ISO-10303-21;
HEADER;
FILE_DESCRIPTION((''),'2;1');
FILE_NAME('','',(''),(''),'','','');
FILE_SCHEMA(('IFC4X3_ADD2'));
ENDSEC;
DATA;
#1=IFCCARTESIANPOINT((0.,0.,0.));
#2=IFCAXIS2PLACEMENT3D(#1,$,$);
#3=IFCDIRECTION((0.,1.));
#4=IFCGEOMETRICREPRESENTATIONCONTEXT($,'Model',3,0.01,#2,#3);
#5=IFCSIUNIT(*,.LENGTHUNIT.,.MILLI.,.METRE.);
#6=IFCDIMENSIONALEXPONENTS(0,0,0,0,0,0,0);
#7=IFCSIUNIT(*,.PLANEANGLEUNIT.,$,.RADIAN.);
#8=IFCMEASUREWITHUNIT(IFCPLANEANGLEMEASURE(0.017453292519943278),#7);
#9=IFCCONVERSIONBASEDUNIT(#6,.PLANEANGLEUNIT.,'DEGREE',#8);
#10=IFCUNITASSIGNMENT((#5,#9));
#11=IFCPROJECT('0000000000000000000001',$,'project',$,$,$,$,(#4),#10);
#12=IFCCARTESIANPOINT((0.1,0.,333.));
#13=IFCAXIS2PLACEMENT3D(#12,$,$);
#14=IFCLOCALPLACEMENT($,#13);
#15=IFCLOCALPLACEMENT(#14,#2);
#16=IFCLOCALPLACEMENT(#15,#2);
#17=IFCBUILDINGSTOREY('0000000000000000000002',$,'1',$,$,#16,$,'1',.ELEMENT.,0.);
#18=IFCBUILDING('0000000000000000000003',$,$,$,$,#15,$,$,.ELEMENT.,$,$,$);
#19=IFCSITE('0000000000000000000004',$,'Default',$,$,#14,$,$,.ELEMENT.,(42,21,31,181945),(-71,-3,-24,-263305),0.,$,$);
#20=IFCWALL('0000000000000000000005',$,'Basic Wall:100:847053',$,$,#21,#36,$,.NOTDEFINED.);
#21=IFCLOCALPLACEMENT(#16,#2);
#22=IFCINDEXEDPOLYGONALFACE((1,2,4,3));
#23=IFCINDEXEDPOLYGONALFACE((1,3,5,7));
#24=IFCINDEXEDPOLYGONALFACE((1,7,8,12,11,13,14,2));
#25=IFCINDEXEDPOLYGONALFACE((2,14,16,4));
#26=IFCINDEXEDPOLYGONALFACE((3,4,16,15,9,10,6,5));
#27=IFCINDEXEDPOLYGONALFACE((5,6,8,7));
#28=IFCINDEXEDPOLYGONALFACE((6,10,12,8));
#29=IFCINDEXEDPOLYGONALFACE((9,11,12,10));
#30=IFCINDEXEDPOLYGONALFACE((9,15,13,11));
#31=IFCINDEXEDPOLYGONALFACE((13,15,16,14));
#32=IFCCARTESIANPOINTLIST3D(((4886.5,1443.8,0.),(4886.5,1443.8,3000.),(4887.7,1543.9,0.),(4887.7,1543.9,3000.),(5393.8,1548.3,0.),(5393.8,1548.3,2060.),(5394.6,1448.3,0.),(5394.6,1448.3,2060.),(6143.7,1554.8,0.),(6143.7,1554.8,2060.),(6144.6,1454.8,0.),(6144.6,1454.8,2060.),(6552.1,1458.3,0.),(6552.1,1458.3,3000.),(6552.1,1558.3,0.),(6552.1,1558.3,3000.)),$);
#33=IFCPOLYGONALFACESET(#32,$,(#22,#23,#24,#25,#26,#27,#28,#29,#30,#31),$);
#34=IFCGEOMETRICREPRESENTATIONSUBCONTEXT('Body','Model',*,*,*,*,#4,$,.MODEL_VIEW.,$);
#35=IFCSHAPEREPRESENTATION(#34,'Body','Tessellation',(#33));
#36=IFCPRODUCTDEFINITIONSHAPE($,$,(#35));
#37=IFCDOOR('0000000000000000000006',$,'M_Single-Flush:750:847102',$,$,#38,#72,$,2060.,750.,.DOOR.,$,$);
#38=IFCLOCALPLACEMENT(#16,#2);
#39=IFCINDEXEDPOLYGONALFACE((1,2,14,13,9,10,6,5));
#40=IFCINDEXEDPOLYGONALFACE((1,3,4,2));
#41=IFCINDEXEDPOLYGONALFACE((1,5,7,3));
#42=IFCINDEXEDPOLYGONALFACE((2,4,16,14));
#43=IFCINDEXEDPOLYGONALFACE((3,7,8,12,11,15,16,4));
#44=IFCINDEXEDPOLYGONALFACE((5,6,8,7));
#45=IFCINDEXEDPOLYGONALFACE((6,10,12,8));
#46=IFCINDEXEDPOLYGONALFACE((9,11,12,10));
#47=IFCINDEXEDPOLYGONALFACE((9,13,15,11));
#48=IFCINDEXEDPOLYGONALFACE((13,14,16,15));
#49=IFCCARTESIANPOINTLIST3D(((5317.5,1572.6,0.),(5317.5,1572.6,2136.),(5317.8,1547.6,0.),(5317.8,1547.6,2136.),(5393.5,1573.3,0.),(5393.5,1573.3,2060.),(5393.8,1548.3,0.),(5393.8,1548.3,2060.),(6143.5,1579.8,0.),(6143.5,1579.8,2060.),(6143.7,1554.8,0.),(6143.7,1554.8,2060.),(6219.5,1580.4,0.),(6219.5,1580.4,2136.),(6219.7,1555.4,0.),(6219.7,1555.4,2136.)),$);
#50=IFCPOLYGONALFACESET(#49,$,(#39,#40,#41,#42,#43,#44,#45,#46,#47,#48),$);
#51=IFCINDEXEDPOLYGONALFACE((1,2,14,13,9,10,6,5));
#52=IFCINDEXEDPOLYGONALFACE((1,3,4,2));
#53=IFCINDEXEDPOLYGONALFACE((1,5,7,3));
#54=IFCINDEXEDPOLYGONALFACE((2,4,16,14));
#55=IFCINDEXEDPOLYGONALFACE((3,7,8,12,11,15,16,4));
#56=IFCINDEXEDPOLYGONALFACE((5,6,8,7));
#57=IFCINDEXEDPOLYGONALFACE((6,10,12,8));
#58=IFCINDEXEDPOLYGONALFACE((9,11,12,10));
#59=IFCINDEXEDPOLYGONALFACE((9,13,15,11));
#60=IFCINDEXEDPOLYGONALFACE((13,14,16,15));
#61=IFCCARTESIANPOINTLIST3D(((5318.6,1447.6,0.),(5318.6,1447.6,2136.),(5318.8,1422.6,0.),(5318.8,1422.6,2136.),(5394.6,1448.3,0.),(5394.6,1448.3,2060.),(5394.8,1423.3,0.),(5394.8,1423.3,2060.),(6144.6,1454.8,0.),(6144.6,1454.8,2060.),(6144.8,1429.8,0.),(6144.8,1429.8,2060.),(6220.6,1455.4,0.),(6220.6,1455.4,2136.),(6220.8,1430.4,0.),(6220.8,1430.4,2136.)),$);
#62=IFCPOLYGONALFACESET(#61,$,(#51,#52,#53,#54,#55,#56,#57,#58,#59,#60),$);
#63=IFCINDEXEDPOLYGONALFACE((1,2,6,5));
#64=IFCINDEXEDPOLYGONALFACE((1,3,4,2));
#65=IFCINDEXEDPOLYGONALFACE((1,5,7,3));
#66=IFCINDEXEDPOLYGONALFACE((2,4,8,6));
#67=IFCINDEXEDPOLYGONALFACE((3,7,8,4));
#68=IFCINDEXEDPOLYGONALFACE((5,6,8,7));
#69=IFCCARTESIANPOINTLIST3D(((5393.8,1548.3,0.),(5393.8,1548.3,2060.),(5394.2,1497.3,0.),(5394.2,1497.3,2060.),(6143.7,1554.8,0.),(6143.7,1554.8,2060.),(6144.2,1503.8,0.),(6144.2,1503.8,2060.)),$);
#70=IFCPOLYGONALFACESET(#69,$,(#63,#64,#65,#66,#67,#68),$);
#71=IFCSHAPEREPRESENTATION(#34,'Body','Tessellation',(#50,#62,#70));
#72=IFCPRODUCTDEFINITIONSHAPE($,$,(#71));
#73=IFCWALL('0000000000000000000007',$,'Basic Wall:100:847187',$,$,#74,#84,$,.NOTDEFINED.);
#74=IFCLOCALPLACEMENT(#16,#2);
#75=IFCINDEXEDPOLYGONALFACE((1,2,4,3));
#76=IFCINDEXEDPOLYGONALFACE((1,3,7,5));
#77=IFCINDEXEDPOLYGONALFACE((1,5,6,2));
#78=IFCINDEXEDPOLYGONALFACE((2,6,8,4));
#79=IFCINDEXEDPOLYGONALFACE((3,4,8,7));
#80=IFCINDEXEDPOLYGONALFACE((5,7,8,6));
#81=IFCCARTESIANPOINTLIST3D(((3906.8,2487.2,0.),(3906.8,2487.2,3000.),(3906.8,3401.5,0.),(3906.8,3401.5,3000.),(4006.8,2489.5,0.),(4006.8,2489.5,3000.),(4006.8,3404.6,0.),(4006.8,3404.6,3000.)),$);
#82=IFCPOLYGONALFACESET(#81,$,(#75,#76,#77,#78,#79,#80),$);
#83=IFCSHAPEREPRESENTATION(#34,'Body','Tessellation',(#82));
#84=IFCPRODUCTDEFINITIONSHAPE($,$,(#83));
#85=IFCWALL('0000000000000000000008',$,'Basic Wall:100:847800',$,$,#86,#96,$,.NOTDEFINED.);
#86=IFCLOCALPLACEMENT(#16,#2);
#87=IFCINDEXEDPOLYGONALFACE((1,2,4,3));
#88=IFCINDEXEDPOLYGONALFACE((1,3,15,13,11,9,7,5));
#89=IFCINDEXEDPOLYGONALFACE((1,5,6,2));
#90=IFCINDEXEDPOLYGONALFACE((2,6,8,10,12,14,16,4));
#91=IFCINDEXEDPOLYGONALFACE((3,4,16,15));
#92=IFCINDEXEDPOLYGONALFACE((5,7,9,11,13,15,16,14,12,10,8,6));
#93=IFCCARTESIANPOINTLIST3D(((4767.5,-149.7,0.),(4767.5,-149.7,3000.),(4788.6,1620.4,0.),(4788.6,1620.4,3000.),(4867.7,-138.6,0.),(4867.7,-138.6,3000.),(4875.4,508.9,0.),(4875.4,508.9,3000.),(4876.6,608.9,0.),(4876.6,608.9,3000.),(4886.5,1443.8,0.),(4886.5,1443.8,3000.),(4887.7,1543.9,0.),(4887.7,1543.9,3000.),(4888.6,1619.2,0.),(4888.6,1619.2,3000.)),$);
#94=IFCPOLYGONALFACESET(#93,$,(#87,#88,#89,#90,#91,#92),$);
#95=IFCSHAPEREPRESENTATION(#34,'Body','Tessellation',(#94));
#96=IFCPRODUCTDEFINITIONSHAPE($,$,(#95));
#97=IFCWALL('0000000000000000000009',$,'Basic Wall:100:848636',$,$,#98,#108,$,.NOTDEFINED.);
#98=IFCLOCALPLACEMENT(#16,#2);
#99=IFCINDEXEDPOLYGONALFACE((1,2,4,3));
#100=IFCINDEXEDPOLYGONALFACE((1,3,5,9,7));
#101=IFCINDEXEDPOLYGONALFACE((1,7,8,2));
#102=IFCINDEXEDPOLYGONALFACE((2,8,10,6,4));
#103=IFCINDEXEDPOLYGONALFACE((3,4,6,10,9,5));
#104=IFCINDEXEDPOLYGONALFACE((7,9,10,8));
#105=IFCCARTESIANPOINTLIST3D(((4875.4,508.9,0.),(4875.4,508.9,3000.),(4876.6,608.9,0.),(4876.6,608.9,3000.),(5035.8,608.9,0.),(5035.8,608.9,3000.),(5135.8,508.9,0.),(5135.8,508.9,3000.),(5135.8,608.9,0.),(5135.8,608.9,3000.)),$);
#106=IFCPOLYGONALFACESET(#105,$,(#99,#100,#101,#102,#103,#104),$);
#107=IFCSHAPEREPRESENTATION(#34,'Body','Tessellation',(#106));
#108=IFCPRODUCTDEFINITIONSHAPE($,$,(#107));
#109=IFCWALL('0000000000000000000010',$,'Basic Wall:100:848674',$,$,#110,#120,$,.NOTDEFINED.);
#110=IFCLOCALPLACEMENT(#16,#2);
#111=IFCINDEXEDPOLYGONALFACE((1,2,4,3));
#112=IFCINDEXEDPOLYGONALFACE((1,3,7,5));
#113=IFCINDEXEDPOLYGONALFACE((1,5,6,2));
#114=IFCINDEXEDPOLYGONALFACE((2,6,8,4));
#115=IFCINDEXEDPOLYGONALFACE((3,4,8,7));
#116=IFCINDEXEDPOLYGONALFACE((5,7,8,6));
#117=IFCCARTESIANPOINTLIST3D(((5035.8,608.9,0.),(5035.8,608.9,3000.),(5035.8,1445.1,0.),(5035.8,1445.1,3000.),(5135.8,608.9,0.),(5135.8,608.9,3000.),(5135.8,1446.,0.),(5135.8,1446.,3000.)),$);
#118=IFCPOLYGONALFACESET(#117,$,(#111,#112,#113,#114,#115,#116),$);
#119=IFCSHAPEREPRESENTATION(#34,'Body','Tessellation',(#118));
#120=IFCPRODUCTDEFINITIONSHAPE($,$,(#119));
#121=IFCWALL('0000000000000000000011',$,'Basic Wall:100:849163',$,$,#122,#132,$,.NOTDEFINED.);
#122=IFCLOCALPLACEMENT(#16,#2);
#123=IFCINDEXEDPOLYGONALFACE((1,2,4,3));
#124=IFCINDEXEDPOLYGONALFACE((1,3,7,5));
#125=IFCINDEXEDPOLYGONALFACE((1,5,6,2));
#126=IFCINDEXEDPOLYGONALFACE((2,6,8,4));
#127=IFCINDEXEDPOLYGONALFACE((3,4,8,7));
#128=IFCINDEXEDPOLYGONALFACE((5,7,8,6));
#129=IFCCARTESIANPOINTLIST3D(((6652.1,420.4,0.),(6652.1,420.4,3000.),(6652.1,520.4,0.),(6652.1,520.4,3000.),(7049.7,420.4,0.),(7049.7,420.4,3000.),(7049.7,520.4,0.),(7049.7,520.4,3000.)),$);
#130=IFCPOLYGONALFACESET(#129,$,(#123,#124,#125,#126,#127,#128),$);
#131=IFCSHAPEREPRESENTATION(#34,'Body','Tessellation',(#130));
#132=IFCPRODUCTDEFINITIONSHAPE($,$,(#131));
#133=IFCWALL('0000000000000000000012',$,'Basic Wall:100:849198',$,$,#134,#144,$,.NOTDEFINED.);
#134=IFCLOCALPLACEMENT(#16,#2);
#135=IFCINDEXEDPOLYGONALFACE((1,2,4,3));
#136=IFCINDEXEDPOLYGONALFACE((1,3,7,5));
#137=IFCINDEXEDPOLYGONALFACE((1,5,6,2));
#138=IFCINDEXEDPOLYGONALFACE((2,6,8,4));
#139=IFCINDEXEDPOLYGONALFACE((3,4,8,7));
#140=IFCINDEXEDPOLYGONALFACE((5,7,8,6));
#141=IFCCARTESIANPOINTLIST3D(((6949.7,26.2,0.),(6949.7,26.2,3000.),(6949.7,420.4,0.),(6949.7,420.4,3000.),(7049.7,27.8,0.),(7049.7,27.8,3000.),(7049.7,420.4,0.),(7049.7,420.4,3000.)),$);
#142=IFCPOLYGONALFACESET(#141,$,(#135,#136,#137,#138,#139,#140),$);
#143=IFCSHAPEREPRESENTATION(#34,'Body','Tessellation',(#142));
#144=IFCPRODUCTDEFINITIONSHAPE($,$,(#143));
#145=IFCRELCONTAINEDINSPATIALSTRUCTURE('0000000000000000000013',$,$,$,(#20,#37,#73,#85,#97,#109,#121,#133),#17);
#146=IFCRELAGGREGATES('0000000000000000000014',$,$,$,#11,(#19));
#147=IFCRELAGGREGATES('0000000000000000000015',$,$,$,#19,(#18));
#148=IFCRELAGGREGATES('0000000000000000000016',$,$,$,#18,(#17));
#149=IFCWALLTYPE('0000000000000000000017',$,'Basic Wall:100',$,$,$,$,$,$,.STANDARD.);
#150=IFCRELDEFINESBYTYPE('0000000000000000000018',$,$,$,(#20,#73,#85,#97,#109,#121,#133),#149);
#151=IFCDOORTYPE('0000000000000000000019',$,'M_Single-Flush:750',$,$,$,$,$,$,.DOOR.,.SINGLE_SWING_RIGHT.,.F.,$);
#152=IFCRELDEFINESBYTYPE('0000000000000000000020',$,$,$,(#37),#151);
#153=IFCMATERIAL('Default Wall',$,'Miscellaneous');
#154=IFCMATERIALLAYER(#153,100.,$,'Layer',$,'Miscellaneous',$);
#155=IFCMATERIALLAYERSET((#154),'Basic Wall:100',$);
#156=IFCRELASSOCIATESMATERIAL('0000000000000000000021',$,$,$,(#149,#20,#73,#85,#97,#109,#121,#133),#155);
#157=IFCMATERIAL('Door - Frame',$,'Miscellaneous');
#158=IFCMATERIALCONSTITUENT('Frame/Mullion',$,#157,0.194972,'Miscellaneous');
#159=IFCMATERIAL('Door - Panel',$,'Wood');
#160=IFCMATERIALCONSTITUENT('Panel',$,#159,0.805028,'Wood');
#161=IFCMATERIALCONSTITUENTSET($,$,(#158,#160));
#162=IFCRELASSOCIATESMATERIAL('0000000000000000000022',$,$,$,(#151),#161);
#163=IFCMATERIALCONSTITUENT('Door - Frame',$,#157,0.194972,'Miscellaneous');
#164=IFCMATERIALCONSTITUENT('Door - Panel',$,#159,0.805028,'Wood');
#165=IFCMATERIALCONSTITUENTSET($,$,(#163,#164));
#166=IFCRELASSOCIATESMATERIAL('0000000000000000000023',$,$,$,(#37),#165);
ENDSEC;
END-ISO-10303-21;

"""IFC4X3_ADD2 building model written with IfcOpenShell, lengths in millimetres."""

from ifc_helpers import new_model, entity, si_unit, converted_unit, direction, frame, frame_2d, origin, origin_2d_with_axis, place, context, subcontext, project, spatial, polyline, rectangle, outline, extrude, source, transform, mapped, material, layer, layer_set, constituent, constituent_set, type_object, type_shapes, element, fill, save


model = new_model("IFC4X3_ADD2")

# Units and contexts
model_context = context("Model", 3, precision=0.01, world=origin(), true_north=direction((0.0, 1.0)))
body_context = subcontext(model_context, "Body", "Model", "MODEL_VIEW")
ifc_project = project(units=[si_unit("LENGTHUNIT", "METRE", prefix="MILLI"), converted_unit("PLANEANGLEUNIT", "DEGREE", entity("IfcPlaneAngleMeasure", 0.017453292519943278), si_unit("PLANEANGLEUNIT", "RADIAN"), dimensions=[0, 0, 0, 0, 0, 0, 0])], contexts=[model_context])

# Site, building, storey
site_placement = place(None, frame((0.1, 0.0, 333.0)))
site = spatial("IfcSite", under=ifc_project, at=site_placement, Name="Default", CompositionType="ELEMENT", RefLatitude=(42, 21, 31, 181945), RefLongitude=(-71, -3, -24, -263305), RefElevation=0.0)
building_placement = place(site_placement, origin())
building = spatial("IfcBuilding", under=site, at=building_placement, CompositionType="ELEMENT")
storey_placement = place(building_placement, origin())
storey = spatial("IfcBuildingStorey", under=building, at=storey_placement, Name="1", LongName="1", CompositionType="ELEMENT", Elevation=0.0)

# Shared definitions
ifc_material_1 = material(Name="Default Wall", Category="Miscellaneous")

# Shared definitions
ifc_material_2 = material(Name="Door - Frame", Category="Miscellaneous")
ifc_material_3 = material(Name="Door - Panel", Category="Wood")

# Shared definitions
ifc_layer_1 = layer(ifc_material_1, 100.0, Name="Layer", Category="Miscellaneous")
ifc_layer_set_1 = layer_set([ifc_layer_1], Name="Basic Wall:100")
wall_type_1 = type_object("IfcWallType", Name="Basic Wall:100", PredefinedType="STANDARD", material=ifc_layer_set_1)

# Wall, opening, door
wall_1_placement = place(storey_placement, frame((4886.1, 1493.8, 0.0), z_axis=(0.0, 0.0, 1.0), x_axis=(0.999962, 0.008695, 0.0)))
wall_1 = element("IfcWall", 1, at=wall_1_placement, inside=storey, type_object=wall_type_1, material=ifc_layer_set_1, Name="Basic Wall:100:847053", PredefinedType="NOTDEFINED", context=body_context, shape_type="SweptSolid", body=[
    extrude(outline(polyline([(0.0, -50.0), (149.3, -50.0), (249.3, -50.0), (1665.6, -50.0), (1666.5, 50.0), (2.1, 50.0), (0.0, -50.0)])), origin(), (0.0, 0.0, 1.0), 3000.0),
])
opening_1_placement = place(wall_1_placement, frame((508.1, -50.0, 0.0)))
opening_1 = element("IfcOpeningElement", 2, at=opening_1_placement, cuts=wall_1, PredefinedType="OPENING", context=body_context, shape_type="SweptSolid", body=[
    extrude(rectangle(XDim=750.0, YDim=2060.0, at=frame_2d((1030.0, 375.0), x_axis=(0.0, 1.0))), frame((0.0, 0.0, 0.0), z_axis=(0.0, 1.0, 0.0), x_axis=(0.0, 0.0, 1.0)), (0.0, 0.0, 1.0), 100.0),
])
ifc_constituent_1 = constituent(ifc_material_2, Name="Door - Frame", Category="Miscellaneous", fraction=0.194972)
ifc_constituent_2 = constituent(ifc_material_3, Name="Door - Panel", Category="Wood", fraction=0.805028)
ifc_constituent_set_1 = constituent_set(constituents=[ifc_constituent_1, ifc_constituent_2])
ifc_constituent_3 = constituent(ifc_material_2, Name="Frame/Mullion", Category="Miscellaneous", fraction=0.194972)
ifc_constituent_4 = constituent(ifc_material_3, Name="Panel", Category="Wood", fraction=0.805028)
ifc_constituent_set_2 = constituent_set(constituents=[ifc_constituent_3, ifc_constituent_4])
door_type_1 = type_object("IfcDoorType", Name="M_Single-Flush:750", OperationType="SINGLE_SWING_RIGHT", ParameterTakesPrecedence=False, PredefinedType="DOOR", material=ifc_constituent_set_2)
shared_shape_1 = source(origin(), body_context, "Body", "SweptSolid", [
    extrude(outline(polyline([(-451.0, -1087.0), (451.0, -1087.0), (451.0, 1049.0), (375.0, 1049.0), (375.0, -1011.0), (-375.0, -1011.0), (-375.0, 1049.0), (-451.0, 1049.0), (-451.0, -1087.0)])), frame((375.0, 100.0, 1049.0), z_axis=(0.0, 1.0, 0.0), x_axis=(1.0, 0.0, 0.0)), (0.0, 0.0, 1.0), 25.0),
    extrude(outline(polyline([(-1087.0, -451.0), (1049.0, -451.0), (1049.0, -375.0), (-1011.0, -375.0), (-1011.0, 375.0), (1049.0, 375.0), (1049.0, 451.0), (-1087.0, 451.0), (-1087.0, -451.0)])), frame((375.0, -25.0, 1049.0), z_axis=(0.0, 1.0, 0.0), x_axis=(0.0, 0.0, -1.0)), (0.0, 0.0, 1.0), 25.0),
    extrude(rectangle(XDim=51.0, YDim=750.0, at=origin_2d_with_axis()), frame((375.0, 74.5, 0.0), z_axis=(0.0, 0.0, 1.0), x_axis=(0.0, 1.0, 0.0)), (0.0, 0.0, 1.0), 2060.0),
])
type_shapes(door_type_1, [shared_shape_1])
door_1_placement = place(opening_1_placement, origin())
door_1 = element("IfcDoor", 3, at=door_1_placement, inside=storey, type_object=door_type_1, material=ifc_constituent_set_1, Name="M_Single-Flush:750:847102", OverallHeight=2060.0, OverallWidth=750.0, PredefinedType="DOOR", context=body_context, shape_type="MappedRepresentation", body=[
    mapped(shared_shape_1, transform((0.0, 0.0, 0.0), scale=1.0)),
])
fill(opening_1, door_1)

# Walls
wall_2_placement = place(storey_placement, frame((3956.8, 3404.6, 0.0), z_axis=(0.0, 0.0, 1.0), x_axis=(0.0, -1.0, 0.0)))
element("IfcWall", 4, at=wall_2_placement, inside=storey, type_object=wall_type_1, material=ifc_layer_set_1, Name="Basic Wall:100:847187", PredefinedType="NOTDEFINED", context=body_context, shape_type="SweptSolid", body=[
    extrude(outline(polyline([(917.4, -50.0), (915.1, 50.0), (0.0, 50.0), (3.1, -50.0), (917.4, -50.0)])), origin(), (0.0, 0.0, 1.0), 3000.0),
])
wall_3_placement = place(storey_placement, frame((4838.6, 1619.8, 0.0), z_axis=(0.0, 0.0, 1.0), x_axis=(-0.011924, -0.999929, 0.0)))
element("IfcWall", 5, at=wall_3_placement, inside=storey, type_object=wall_type_1, material=ifc_layer_set_1, Name="Basic Wall:100:847800", PredefinedType="NOTDEFINED", context=body_context, shape_type="SweptSolid", body=[
    extrude(outline(polyline([(1770.2, -50.0), (1757.9, 50.0), (1110.4, 50.0), (1010.4, 50.0), (175.4, 50.0), (75.4, 50.0), (0.0, 50.0), (0.0, -50.0), (1770.2, -50.0)])), origin(), (0.0, 0.0, 1.0), 3000.0),
])
wall_4_placement = place(storey_placement, frame((5135.8, 558.9, 0.0), z_axis=(0.0, 0.0, 1.0), x_axis=(-1.0, 0.0, 0.0)))
element("IfcWall", 6, at=wall_4_placement, inside=storey, type_object=wall_type_1, material=ifc_layer_set_1, Name="Basic Wall:100:848636", PredefinedType="NOTDEFINED", context=body_context, shape_type="SweptSolid", body=[
    extrude(outline(polyline([(259.2, -50.0), (260.4, 50.0), (0.0, 50.0), (0.0, -50.0), (100.0, -50.0), (259.2, -50.0)])), origin(), (0.0, 0.0, 1.0), 3000.0),
])
wall_5_placement = place(storey_placement, frame((5085.8, 1446.0, 0.0), z_axis=(0.0, 0.0, 1.0), x_axis=(0.0, -1.0, 0.0)))
element("IfcWall", 7, at=wall_5_placement, inside=storey, type_object=wall_type_1, material=ifc_layer_set_1, Name="Basic Wall:100:848674", PredefinedType="NOTDEFINED", context=body_context, shape_type="SweptSolid", body=[
    extrude(outline(polyline([(837.1, -50.0), (837.1, 50.0), (0.0, 50.0), (0.9, -50.0), (837.1, -50.0)])), origin(), (0.0, 0.0, 1.0), 3000.0),
])
wall_6_placement = place(storey_placement, frame((7049.7, 470.4, 0.0), z_axis=(0.0, 0.0, 1.0), x_axis=(-1.0, 0.0, 0.0)))
element("IfcWall", 8, at=wall_6_placement, inside=storey, type_object=wall_type_1, material=ifc_layer_set_1, Name="Basic Wall:100:849163", PredefinedType="NOTDEFINED", context=body_context, shape_type="SweptSolid", body=[
    extrude(rectangle(XDim=397.6, YDim=100.0, at=frame_2d((198.8, 0.0), x_axis=(-1.0, 0.0))), origin(), (0.0, 0.0, 1.0), 3000.0),
])
wall_7_placement = place(storey_placement, frame((6999.7, 420.4, 0.0), z_axis=(0.0, 0.0, 1.0), x_axis=(0.0, -1.0, 0.0)))
element("IfcWall", 9, at=wall_7_placement, inside=storey, type_object=wall_type_1, material=ifc_layer_set_1, Name="Basic Wall:100:849198", PredefinedType="NOTDEFINED", context=body_context, shape_type="SweptSolid", body=[
    extrude(outline(polyline([(394.2, -50.0), (392.6, 50.0), (0.0, 50.0), (0.0, -50.0), (394.2, -50.0)])), origin(), (0.0, 0.0, 1.0), 3000.0),
])

save(model, "model.ifc")
